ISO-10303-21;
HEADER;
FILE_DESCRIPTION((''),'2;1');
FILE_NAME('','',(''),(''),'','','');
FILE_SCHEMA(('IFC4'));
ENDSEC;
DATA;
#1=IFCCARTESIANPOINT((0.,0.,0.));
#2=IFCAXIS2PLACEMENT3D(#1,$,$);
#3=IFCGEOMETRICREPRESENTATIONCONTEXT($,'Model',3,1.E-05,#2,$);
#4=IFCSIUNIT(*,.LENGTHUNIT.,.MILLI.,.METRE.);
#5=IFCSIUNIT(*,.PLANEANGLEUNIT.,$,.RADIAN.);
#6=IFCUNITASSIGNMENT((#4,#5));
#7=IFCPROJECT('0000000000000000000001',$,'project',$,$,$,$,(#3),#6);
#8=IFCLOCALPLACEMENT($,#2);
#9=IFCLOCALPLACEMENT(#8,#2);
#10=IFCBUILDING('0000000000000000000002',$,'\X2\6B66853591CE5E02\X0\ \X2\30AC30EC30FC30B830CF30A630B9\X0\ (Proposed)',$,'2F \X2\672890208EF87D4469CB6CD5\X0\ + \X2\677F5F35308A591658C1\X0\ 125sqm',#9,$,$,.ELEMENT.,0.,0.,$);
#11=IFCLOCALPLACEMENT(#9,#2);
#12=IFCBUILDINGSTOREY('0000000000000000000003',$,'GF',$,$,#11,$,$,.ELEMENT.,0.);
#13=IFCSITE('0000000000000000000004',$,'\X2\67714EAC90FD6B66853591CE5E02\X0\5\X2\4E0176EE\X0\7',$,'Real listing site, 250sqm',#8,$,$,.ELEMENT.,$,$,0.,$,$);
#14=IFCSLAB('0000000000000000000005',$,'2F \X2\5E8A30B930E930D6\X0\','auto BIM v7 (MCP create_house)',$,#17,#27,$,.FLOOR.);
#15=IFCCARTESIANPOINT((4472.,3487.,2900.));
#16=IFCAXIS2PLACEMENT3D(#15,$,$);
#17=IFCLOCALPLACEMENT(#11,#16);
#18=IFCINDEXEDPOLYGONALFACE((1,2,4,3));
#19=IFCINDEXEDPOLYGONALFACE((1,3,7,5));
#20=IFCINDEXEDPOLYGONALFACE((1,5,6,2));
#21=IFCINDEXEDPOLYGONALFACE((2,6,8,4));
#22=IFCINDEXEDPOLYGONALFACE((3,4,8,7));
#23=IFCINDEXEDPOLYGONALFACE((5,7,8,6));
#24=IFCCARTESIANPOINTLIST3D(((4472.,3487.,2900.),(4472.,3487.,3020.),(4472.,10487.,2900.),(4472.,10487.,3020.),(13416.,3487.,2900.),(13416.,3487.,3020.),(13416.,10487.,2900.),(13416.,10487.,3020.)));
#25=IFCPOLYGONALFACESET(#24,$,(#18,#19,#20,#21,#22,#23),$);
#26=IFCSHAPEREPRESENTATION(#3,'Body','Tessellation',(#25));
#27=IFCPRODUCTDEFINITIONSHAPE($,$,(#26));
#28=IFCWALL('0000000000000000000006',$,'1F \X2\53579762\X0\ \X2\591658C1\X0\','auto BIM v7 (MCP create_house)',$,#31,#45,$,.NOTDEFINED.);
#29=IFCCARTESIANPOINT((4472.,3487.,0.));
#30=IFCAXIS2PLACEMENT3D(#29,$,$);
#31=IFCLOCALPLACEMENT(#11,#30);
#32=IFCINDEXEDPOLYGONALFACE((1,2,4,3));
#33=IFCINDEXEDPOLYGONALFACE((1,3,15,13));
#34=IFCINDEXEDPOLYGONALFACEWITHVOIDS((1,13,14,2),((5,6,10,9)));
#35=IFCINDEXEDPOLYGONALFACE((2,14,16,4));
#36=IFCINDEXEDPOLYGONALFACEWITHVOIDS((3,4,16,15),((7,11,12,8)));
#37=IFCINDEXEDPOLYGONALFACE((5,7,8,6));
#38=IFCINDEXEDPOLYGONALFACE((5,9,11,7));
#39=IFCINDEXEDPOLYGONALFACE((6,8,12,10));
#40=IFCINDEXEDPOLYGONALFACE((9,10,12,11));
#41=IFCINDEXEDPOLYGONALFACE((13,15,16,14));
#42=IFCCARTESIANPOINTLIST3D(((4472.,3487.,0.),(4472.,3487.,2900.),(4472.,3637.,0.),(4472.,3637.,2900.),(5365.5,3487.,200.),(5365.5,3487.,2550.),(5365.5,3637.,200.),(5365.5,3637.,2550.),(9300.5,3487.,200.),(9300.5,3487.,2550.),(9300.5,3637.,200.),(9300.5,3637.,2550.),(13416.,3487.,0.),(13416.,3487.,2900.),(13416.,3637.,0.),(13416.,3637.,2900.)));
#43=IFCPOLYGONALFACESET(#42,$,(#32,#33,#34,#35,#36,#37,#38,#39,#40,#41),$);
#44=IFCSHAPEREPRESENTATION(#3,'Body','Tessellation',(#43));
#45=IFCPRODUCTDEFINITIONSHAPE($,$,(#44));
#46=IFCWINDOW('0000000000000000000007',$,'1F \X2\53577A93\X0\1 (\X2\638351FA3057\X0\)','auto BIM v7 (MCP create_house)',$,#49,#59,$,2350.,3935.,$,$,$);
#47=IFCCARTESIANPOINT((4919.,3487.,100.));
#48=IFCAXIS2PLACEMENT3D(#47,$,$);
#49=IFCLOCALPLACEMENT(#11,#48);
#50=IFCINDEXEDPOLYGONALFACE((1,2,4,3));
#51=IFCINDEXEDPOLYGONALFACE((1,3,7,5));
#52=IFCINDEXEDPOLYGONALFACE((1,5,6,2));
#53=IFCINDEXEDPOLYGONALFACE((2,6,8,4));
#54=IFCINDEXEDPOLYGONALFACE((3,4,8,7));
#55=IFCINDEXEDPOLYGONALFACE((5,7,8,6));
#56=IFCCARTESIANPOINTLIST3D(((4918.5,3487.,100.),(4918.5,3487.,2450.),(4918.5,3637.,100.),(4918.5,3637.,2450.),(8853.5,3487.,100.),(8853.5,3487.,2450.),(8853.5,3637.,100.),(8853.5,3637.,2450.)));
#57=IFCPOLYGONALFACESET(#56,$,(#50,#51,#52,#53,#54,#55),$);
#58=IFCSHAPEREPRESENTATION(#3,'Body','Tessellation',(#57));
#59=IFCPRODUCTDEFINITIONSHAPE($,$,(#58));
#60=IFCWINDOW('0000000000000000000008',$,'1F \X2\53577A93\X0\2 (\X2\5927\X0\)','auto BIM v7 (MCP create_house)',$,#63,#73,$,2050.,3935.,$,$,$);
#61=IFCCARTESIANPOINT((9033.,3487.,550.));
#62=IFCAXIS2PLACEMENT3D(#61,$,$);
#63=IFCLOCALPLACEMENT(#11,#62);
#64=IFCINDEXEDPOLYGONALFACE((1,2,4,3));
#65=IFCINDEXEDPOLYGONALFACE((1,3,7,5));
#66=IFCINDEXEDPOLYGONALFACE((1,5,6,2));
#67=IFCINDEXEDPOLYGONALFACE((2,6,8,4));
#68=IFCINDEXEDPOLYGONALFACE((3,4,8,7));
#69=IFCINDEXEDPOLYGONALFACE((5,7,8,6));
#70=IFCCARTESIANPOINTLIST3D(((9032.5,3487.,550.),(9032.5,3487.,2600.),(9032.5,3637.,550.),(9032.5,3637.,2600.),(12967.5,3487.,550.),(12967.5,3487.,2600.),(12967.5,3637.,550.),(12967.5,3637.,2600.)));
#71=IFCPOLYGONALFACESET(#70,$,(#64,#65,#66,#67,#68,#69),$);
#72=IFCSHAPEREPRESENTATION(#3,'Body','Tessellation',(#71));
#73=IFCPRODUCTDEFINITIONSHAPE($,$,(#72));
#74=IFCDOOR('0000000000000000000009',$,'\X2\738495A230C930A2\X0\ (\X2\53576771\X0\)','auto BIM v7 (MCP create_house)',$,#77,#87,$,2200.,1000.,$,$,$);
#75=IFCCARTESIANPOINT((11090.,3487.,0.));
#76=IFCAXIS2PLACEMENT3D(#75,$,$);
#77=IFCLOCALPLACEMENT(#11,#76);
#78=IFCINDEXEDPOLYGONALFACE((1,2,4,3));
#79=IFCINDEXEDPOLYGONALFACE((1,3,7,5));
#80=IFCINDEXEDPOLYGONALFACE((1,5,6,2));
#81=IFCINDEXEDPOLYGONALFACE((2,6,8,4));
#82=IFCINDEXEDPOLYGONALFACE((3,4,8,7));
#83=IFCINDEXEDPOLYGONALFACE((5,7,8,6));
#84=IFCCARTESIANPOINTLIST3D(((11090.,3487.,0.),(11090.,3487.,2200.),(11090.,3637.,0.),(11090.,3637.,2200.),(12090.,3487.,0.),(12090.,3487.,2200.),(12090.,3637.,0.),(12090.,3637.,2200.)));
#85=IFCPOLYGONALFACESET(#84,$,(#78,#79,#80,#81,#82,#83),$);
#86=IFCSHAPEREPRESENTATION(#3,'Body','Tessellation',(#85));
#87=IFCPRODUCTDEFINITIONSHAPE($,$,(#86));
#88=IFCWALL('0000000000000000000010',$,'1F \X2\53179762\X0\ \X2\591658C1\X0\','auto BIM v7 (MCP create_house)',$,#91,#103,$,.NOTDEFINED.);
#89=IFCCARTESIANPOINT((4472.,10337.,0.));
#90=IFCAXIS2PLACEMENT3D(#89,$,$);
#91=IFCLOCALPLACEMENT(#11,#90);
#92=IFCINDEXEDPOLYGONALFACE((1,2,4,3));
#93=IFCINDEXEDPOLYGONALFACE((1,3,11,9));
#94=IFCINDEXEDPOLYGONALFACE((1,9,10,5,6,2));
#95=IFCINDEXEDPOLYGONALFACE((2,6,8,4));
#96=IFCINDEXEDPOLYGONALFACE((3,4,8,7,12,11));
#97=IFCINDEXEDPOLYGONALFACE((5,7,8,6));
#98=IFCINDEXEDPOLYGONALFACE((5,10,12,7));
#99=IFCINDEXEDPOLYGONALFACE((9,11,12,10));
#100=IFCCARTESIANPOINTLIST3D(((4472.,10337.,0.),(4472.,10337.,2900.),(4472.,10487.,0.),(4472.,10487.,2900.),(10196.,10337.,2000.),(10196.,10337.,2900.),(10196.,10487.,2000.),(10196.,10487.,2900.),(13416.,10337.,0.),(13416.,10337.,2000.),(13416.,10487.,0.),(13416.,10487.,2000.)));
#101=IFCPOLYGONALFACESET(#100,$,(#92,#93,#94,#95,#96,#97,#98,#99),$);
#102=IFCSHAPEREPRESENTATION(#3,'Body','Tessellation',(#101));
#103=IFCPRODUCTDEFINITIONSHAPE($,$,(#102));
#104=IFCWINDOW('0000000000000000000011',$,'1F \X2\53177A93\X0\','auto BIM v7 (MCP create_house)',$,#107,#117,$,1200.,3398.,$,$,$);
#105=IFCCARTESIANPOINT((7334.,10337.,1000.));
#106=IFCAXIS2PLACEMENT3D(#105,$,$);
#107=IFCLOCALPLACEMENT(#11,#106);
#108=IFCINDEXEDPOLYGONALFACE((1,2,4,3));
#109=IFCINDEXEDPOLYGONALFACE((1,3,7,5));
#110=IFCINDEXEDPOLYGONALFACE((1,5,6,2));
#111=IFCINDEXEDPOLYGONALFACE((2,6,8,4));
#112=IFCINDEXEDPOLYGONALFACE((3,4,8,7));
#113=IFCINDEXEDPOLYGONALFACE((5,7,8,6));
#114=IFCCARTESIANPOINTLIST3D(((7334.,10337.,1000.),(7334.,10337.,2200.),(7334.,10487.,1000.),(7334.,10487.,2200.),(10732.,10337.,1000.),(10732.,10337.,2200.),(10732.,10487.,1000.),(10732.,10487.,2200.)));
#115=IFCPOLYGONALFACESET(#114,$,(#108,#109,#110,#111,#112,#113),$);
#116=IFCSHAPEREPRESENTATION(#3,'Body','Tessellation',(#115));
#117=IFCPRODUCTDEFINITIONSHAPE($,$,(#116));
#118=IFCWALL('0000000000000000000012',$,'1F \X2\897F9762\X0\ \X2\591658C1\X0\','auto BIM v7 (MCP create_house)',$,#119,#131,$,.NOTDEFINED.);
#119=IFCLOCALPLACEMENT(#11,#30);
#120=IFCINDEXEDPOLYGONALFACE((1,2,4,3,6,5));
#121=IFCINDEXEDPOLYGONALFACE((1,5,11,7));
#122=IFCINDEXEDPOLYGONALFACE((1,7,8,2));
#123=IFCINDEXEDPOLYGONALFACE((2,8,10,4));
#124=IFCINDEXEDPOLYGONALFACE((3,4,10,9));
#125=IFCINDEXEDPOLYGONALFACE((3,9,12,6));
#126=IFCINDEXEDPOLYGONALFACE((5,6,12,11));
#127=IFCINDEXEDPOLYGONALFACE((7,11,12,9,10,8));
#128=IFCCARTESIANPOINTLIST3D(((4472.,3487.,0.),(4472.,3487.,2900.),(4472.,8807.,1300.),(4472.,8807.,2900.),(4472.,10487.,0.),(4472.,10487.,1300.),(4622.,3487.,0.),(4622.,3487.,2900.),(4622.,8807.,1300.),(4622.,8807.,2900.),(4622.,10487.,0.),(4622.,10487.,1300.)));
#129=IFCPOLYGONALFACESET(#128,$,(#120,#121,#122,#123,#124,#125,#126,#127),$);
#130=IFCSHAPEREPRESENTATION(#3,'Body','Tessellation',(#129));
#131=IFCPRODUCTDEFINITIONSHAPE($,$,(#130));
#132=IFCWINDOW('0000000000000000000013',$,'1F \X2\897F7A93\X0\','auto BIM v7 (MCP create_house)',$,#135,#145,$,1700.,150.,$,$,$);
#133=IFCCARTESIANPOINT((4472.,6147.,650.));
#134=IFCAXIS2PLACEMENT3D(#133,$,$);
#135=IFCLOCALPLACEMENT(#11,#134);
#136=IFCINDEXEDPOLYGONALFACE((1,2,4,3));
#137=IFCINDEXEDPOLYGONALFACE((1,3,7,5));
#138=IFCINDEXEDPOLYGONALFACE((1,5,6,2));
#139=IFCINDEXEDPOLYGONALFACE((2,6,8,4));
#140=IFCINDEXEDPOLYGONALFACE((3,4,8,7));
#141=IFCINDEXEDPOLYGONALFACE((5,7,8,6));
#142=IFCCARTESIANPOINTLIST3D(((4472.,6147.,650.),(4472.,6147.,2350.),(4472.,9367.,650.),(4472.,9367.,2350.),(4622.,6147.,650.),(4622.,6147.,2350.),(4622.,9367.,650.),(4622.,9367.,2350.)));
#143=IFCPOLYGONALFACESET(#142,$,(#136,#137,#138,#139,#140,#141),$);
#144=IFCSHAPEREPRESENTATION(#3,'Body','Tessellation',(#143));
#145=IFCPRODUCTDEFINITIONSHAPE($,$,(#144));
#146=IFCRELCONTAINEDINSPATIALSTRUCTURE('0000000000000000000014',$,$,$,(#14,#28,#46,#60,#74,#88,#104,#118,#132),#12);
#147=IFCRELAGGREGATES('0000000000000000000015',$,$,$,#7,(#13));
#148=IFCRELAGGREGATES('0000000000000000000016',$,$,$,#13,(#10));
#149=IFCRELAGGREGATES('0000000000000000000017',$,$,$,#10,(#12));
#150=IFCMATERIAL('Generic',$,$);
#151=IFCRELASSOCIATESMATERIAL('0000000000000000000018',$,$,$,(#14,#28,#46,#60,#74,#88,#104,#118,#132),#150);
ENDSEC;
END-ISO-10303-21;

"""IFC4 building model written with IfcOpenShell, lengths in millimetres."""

from ifc_helpers import new_model, si_unit, frame, frame_2d, origin, place, context, project, spatial, rectangle, extrude, material, element, fill, save


model = new_model("IFC4")

# Units and contexts
model_context = context("Model", 3, precision=1e-05, world=origin())
ifc_project = project(units=[si_unit("LENGTHUNIT", "METRE", prefix="MILLI"), si_unit("PLANEANGLEUNIT", "RADIAN")], contexts=[model_context])

# Site, building, storey
site_placement = place(None, origin())
site = spatial("IfcSite", under=ifc_project, at=site_placement, Name="東京都武蔵野市5丁目7", ObjectType="Real listing site, 250sqm", CompositionType="ELEMENT", RefElevation=0.0)
building_placement = place(site_placement, origin())
building = spatial("IfcBuilding", under=site, at=building_placement, Name="武蔵野市 ガレージハウス (Proposed)", ObjectType="2F 木造軸組構法 + 板張り外壁 125sqm", CompositionType="ELEMENT", ElevationOfRefHeight=0.0, ElevationOfTerrain=0.0)
storey_placement = place(building_placement, origin())
storey = spatial("IfcBuildingStorey", under=building, at=storey_placement, Name="GF", CompositionType="ELEMENT", Elevation=0.0)

# Slab
ifc_material = material(Name="Generic")
slab_1_placement = place(storey_placement, frame((4472.0, 3487.0, 2900.0)))
element("IfcSlab", 1, at=slab_1_placement, inside=storey, material=ifc_material, Name="2F 床スラブ", Description="auto BIM v7 (MCP create_house)", PredefinedType="FLOOR", context=model_context, shape_type="SweptSolid", body=[
    extrude(rectangle(XDim=8944.0, YDim=7000.0, at=frame_2d((4472.0, 3500.0))), frame((4472.0, 3487.0, 2900.0)), (0.0, 0.0, 1.0), 120.0),
])

# Wall, openings, windows, door
wall_1_placement = place(storey_placement, frame((4472.0, 3487.0, 0.0)))
wall_1 = element("IfcWall", 2, at=wall_1_placement, inside=storey, material=ifc_material, Name="1F 南面 外壁", Description="auto BIM v7 (MCP create_house)", PredefinedType="NOTDEFINED", context=model_context, shape_type="SweptSolid", body=[
    extrude(rectangle(XDim=8944.0, YDim=150.0, at=frame_2d((4472.0, 75.0))), frame((4472.0, 3487.0, 0.0)), (0.0, 0.0, 1.0), 2900.0),
])
opening_1_placement = place(storey_placement, frame((4919.0, 3487.0, 100.0)))
opening_1 = element("IfcOpeningElement", 3, at=opening_1_placement, cuts=wall_1, PredefinedType="NOTDEFINED", context=model_context, shape_type="SweptSolid", body=[
    extrude(rectangle(XDim=3935.0, YDim=150.0, at=frame_2d((1967.0, 75.0))), frame((4919.0, 3487.0, 100.0)), (0.0, 0.0, 1.0), 2350.0),
])
opening_2_placement = place(storey_placement, frame((9033.0, 3487.0, 550.0)))
opening_2 = element("IfcOpeningElement", 4, at=opening_2_placement, cuts=wall_1, PredefinedType="NOTDEFINED", context=model_context, shape_type="SweptSolid", body=[
    extrude(rectangle(XDim=3935.0, YDim=150.0, at=frame_2d((1967.0, 75.0))), frame((9033.0, 3487.0, 550.0)), (0.0, 0.0, 1.0), 2050.0),
])
opening_3_placement = place(storey_placement, frame((11090.0, 3487.0, 0.0)))
opening_3 = element("IfcOpeningElement", 5, at=opening_3_placement, cuts=wall_1, PredefinedType="NOTDEFINED", context=model_context, shape_type="SweptSolid", body=[
    extrude(rectangle(XDim=1000.0, YDim=150.0, at=frame_2d((500.0, 75.0))), frame((11090.0, 3487.0, 0.0)), (0.0, 0.0, 1.0), 2200.0),
])
window_1_placement = place(storey_placement, frame((4919.0, 3487.0, 100.0)))
window_1 = element("IfcWindow", 6, at=window_1_placement, inside=storey, material=ifc_material, Name="1F 南窓1 (掃出し)", Description="auto BIM v7 (MCP create_house)", OverallHeight=2350.0, OverallWidth=3935.0, context=model_context, shape_type="SweptSolid", body=[
    extrude(rectangle(XDim=3935.0, YDim=150.0, at=frame_2d((1967.0, 75.0))), frame((4919.0, 3487.0, 100.0)), (0.0, 0.0, 1.0), 2350.0),
])
fill(opening_1, window_1)
window_2_placement = place(storey_placement, frame((9033.0, 3487.0, 550.0)))
window_2 = element("IfcWindow", 7, at=window_2_placement, inside=storey, material=ifc_material, Name="1F 南窓2 (大)", Description="auto BIM v7 (MCP create_house)", OverallHeight=2050.0, OverallWidth=3935.0, context=model_context, shape_type="SweptSolid", body=[
    extrude(rectangle(XDim=3935.0, YDim=150.0, at=frame_2d((1967.0, 75.0))), frame((9033.0, 3487.0, 550.0)), (0.0, 0.0, 1.0), 2050.0),
])
fill(opening_2, window_2)
door_placement = place(storey_placement, frame((11090.0, 3487.0, 0.0)))
door = element("IfcDoor", 8, at=door_placement, inside=storey, material=ifc_material, Name="玄関ドア (南東)", Description="auto BIM v7 (MCP create_house)", OverallHeight=2200.0, OverallWidth=1000.0, context=model_context, shape_type="SweptSolid", body=[
    extrude(rectangle(XDim=1000.0, YDim=150.0, at=frame_2d((500.0, 75.0))), frame((11090.0, 3487.0, 0.0)), (0.0, 0.0, 1.0), 2200.0),
])
fill(opening_3, door)

# Walls, openings, windows
wall_2_placement = place(storey_placement, frame((4472.0, 10337.0, 0.0)))
wall_2 = element("IfcWall", 9, at=wall_2_placement, inside=storey, material=ifc_material, Name="1F 北面 外壁", Description="auto BIM v7 (MCP create_house)", PredefinedType="NOTDEFINED", context=model_context, shape_type="SweptSolid", body=[
    extrude(rectangle(XDim=8944.0, YDim=150.0, at=frame_2d((4472.0, 75.0))), frame((4472.0, 10337.0, 0.0)), (0.0, 0.0, 1.0), 2900.0),
])
opening_4_placement = place(storey_placement, frame((7334.0, 10337.0, 1000.0)))
opening_4 = element("IfcOpeningElement", 10, at=opening_4_placement, cuts=wall_2, PredefinedType="NOTDEFINED", context=model_context, shape_type="SweptSolid", body=[
    extrude(rectangle(XDim=3398.0, YDim=150.0, at=frame_2d((1699.0, 75.0))), frame((7334.0, 10337.0, 1000.0)), (0.0, 0.0, 1.0), 1200.0),
])
window_3_placement = place(storey_placement, frame((7334.0, 10337.0, 1000.0)))
window_3 = element("IfcWindow", 11, at=window_3_placement, inside=storey, material=ifc_material, Name="1F 北窓", Description="auto BIM v7 (MCP create_house)", OverallHeight=1200.0, OverallWidth=3398.0, context=model_context, shape_type="SweptSolid", body=[
    extrude(rectangle(XDim=3398.0, YDim=150.0, at=frame_2d((1699.0, 75.0))), frame((7334.0, 10337.0, 1000.0)), (0.0, 0.0, 1.0), 1200.0),
])
fill(opening_4, window_3)
wall_3_placement = place(storey_placement, frame((4472.0, 3487.0, 0.0)))
wall_3 = element("IfcWall", 12, at=wall_3_placement, inside=storey, material=ifc_material, Name="1F 西面 外壁", Description="auto BIM v7 (MCP create_house)", PredefinedType="NOTDEFINED", context=model_context, shape_type="SweptSolid", body=[
    extrude(rectangle(XDim=150.0, YDim=7000.0, at=frame_2d((75.0, 3500.0))), frame((4472.0, 3487.0, 0.0)), (0.0, 0.0, 1.0), 2900.0),
])
opening_5_placement = place(storey_placement, frame((4472.0, 6147.0, 650.0)))
opening_5 = element("IfcOpeningElement", 13, at=opening_5_placement, cuts=wall_3, PredefinedType="NOTDEFINED", context=model_context, shape_type="SweptSolid", body=[
    extrude(rectangle(XDim=150.0, YDim=3220.0, at=frame_2d((75.0, 1610.0))), frame((4472.0, 6147.0, 650.0)), (0.0, 0.0, 1.0), 1700.0),
])
window_4_placement = place(storey_placement, frame((4472.0, 6147.0, 650.0)))
window_4 = element("IfcWindow", 14, at=window_4_placement, inside=storey, material=ifc_material, Name="1F 西窓", Description="auto BIM v7 (MCP create_house)", OverallHeight=1700.0, OverallWidth=150.0, context=model_context, shape_type="SweptSolid", body=[
    extrude(rectangle(XDim=150.0, YDim=3220.0, at=frame_2d((75.0, 1610.0))), frame((4472.0, 6147.0, 650.0)), (0.0, 0.0, 1.0), 1700.0),
])
fill(opening_5, window_4)

save(model, "model.ifc")
